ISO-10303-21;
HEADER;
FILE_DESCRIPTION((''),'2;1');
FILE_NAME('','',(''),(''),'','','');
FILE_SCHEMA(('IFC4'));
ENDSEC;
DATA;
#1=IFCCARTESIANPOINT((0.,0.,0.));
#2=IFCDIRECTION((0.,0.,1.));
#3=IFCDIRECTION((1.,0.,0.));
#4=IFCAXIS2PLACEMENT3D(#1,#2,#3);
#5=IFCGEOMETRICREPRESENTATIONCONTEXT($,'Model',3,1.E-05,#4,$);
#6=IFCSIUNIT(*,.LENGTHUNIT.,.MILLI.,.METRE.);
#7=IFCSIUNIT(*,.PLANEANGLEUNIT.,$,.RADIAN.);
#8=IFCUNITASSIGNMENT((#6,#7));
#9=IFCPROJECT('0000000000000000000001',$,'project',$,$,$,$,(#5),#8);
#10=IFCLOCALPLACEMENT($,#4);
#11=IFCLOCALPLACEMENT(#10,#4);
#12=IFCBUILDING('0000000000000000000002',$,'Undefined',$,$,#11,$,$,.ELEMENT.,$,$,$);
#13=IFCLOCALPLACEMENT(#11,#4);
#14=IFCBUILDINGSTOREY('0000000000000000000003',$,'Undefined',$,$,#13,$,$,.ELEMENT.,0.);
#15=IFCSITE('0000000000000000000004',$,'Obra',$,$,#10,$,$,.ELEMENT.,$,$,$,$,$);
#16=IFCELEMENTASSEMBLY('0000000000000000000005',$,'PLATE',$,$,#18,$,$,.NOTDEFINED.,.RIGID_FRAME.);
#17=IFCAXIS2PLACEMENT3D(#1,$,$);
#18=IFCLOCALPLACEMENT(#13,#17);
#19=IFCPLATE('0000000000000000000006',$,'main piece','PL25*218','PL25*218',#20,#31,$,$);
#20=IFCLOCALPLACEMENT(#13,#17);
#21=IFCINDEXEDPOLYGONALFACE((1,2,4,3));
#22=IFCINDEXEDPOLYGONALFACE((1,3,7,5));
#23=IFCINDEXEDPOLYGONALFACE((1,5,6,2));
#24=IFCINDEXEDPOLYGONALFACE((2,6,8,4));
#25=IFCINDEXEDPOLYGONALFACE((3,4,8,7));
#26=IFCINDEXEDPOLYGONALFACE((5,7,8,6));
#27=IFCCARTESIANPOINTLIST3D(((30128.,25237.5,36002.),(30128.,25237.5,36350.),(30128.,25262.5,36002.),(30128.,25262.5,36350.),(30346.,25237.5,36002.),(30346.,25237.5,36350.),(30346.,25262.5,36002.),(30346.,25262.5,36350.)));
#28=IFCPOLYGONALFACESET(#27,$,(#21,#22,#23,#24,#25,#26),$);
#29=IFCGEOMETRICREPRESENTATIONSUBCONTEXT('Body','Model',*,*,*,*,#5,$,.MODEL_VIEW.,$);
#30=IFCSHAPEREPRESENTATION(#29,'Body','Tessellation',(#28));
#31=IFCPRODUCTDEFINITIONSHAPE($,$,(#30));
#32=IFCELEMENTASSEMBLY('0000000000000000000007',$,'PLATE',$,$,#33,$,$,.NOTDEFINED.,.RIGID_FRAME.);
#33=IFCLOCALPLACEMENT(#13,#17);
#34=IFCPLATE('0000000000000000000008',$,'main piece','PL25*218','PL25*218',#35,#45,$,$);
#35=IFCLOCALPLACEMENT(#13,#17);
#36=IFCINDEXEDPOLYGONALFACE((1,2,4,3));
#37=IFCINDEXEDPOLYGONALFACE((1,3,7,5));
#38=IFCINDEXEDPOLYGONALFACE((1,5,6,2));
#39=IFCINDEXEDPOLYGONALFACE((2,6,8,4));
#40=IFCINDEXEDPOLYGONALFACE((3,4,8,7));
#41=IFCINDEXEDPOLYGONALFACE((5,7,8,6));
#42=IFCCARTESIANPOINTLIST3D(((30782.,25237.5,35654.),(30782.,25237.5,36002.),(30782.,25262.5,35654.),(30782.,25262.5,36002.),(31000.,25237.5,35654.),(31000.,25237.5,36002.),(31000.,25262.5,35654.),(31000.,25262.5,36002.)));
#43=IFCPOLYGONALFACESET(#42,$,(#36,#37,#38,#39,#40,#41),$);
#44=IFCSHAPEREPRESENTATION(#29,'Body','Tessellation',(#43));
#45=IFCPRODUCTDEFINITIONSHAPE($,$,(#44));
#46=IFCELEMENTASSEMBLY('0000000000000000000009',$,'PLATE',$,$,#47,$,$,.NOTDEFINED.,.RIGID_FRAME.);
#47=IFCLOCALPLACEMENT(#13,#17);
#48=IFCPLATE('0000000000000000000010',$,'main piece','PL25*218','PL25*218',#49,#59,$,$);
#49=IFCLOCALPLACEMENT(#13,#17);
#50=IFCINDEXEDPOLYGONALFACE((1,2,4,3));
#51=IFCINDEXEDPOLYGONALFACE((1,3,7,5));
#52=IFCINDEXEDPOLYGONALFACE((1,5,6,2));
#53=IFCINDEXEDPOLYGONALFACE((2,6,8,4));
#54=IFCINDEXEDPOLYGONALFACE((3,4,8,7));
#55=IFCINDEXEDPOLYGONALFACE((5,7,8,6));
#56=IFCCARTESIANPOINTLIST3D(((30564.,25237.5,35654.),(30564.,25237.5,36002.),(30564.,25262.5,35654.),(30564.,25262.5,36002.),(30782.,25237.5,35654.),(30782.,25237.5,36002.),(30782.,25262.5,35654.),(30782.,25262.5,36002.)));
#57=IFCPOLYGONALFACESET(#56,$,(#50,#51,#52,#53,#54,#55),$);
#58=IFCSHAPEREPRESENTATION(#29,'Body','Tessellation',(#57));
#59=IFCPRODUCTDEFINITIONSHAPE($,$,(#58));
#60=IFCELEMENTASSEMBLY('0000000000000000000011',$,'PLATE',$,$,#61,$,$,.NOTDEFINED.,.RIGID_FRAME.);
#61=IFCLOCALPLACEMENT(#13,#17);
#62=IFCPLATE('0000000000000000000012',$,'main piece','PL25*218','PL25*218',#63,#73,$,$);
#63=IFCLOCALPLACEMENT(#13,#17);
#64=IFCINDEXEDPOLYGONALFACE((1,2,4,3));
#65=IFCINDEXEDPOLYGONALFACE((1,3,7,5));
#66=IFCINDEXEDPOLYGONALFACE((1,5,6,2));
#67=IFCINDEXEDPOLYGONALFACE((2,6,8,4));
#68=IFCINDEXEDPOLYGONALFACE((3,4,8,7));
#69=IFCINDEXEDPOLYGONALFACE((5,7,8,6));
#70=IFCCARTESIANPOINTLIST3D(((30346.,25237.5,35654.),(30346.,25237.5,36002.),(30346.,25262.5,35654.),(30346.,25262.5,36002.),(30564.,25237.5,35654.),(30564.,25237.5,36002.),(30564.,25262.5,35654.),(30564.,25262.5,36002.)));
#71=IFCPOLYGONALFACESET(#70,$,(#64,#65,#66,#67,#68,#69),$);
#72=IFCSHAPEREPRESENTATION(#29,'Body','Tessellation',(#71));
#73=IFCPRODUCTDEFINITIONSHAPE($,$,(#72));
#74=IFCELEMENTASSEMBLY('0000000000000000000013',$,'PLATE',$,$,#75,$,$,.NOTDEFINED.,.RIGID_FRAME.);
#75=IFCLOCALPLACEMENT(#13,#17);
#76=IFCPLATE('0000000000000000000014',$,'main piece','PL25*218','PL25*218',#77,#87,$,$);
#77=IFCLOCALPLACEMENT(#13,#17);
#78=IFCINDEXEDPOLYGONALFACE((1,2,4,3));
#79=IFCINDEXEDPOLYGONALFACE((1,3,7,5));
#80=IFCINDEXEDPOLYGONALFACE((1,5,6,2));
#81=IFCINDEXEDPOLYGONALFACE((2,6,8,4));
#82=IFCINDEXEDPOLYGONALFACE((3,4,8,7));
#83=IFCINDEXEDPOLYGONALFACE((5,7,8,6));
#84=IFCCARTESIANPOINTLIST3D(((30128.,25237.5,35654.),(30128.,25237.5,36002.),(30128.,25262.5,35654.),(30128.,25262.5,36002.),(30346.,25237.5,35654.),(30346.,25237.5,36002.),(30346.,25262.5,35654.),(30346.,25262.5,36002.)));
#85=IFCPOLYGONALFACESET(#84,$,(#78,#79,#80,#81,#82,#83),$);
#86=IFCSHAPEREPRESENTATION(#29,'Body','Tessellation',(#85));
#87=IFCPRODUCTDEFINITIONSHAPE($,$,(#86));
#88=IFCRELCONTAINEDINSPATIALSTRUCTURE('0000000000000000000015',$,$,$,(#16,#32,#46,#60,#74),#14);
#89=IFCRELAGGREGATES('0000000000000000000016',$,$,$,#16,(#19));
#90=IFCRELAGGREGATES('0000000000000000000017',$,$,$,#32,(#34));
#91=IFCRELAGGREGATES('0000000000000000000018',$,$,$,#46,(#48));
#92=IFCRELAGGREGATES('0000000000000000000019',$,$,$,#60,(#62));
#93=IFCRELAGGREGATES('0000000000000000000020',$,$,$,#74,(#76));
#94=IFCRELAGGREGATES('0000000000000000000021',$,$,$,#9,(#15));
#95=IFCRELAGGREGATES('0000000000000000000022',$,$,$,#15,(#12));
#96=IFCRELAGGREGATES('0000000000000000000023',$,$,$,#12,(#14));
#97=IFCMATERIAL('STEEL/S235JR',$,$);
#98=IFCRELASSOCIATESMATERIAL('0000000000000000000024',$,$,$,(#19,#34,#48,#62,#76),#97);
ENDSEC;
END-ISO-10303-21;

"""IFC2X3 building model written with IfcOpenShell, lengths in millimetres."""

from ifc_helpers import new_model, si_unit, frame, origin_with_axes, place, context, subcontext, project, spatial, polyline, outline, extrude, material, element, aggregate, save


model = new_model("IFC2X3")

# Units and contexts
model_context = context("Model", 3, precision=1e-05, world=origin_with_axes())
body_context = subcontext(model_context, "Body", "Model", "MODEL_VIEW")
ifc_project = project(units=[si_unit("LENGTHUNIT", "METRE", prefix="MILLI"), si_unit("PLANEANGLEUNIT", "RADIAN")], contexts=[model_context])

# Site, building, storey
site_placement = place(None, origin_with_axes())
site = spatial("IfcSite", under=ifc_project, at=site_placement, Name="Obra", CompositionType="ELEMENT")
building_placement = place(site_placement, origin_with_axes())
building = spatial("IfcBuilding", under=site, at=building_placement, Name="Undefined", CompositionType="ELEMENT")
storey_placement = place(building_placement, origin_with_axes())
storey = spatial("IfcBuildingStorey", under=building, at=storey_placement, Name="Undefined", CompositionType="ELEMENT", Elevation=0.0)

# Shared definitions
ifc_material_1 = material(Name="STEEL/S235JR")

# Element assemblies, plates
assembly_1_placement = place(storey_placement, origin_with_axes())
assembly_1 = element("IfcElementAssembly", 1, at=assembly_1_placement, inside=storey, Name="PLATE", AssemblyPlace="NOTDEFINED", PredefinedType="RIGID_FRAME")
plate_1_placement = place(assembly_1_placement, frame((30128.0, 25250.0, 36002.0), z_axis=(0.0, -1.0, 0.0), x_axis=(1.0, 0.0, 0.0)))
plate_1 = element("IfcPlate", 2, at=plate_1_placement, material=ifc_material_1, Name="main piece", Description="PL25*218", ObjectType="PL25*218", context=body_context, shape_type="SweptSolid", body=[
    extrude(outline(polyline([(0.0, 0.0), (218.0, 0.0), (218.0, 348.0), (0.0, 348.0), (0.0, 0.0)])), frame((0.0, 0.0, -12.5), z_axis=(0.0, 0.0, 1.0), x_axis=(1.0, 0.0, 0.0)), (0.0, 0.0, 1.0), 25.0),
])
aggregate(assembly_1, [plate_1])
assembly_2_placement = place(storey_placement, origin_with_axes())
assembly_2 = element("IfcElementAssembly", 3, at=assembly_2_placement, inside=storey, Name="PLATE", AssemblyPlace="NOTDEFINED", PredefinedType="RIGID_FRAME")
plate_2_placement = place(assembly_2_placement, frame((30782.0, 25250.0, 35654.0), z_axis=(0.0, -1.0, 0.0), x_axis=(1.0, 0.0, 0.0)))
plate_2 = element("IfcPlate", 4, at=plate_2_placement, material=ifc_material_1, Name="main piece", Description="PL25*218", ObjectType="PL25*218", context=body_context, shape_type="SweptSolid", body=[
    extrude(outline(polyline([(0.0, 0.0), (218.0, 0.0), (218.0, 348.0), (0.0, 348.0), (0.0, 0.0)])), frame((0.0, 0.0, -12.5), z_axis=(0.0, 0.0, 1.0), x_axis=(1.0, 0.0, 0.0)), (0.0, 0.0, 1.0), 25.0),
])
aggregate(assembly_2, [plate_2])
assembly_3_placement = place(storey_placement, origin_with_axes())
assembly_3 = element("IfcElementAssembly", 5, at=assembly_3_placement, inside=storey, Name="PLATE", AssemblyPlace="NOTDEFINED", PredefinedType="RIGID_FRAME")
plate_3_placement = place(assembly_3_placement, frame((30564.0, 25250.0, 35654.0), z_axis=(0.0, -1.0, 0.0), x_axis=(1.0, 0.0, 0.0)))
plate_3 = element("IfcPlate", 6, at=plate_3_placement, material=ifc_material_1, Name="main piece", Description="PL25*218", ObjectType="PL25*218", context=body_context, shape_type="SweptSolid", body=[
    extrude(outline(polyline([(0.0, 0.0), (218.0, 0.0), (218.0, 348.0), (0.0, 348.0), (0.0, 0.0)])), frame((0.0, 0.0, -12.5), z_axis=(0.0, 0.0, 1.0), x_axis=(1.0, 0.0, 0.0)), (0.0, 0.0, 1.0), 25.0),
])
aggregate(assembly_3, [plate_3])
assembly_4_placement = place(storey_placement, origin_with_axes())
assembly_4 = element("IfcElementAssembly", 7, at=assembly_4_placement, inside=storey, Name="PLATE", AssemblyPlace="NOTDEFINED", PredefinedType="RIGID_FRAME")
plate_4_placement = place(assembly_4_placement, frame((30346.0, 25250.0, 35654.0), z_axis=(0.0, -1.0, 0.0), x_axis=(1.0, 0.0, 0.0)))
plate_4 = element("IfcPlate", 8, at=plate_4_placement, material=ifc_material_1, Name="main piece", Description="PL25*218", ObjectType="PL25*218", context=body_context, shape_type="SweptSolid", body=[
    extrude(outline(polyline([(0.0, 0.0), (218.0, 0.0), (218.0, 348.0), (0.0, 348.0), (0.0, 0.0)])), frame((0.0, 0.0, -12.5), z_axis=(0.0, 0.0, 1.0), x_axis=(1.0, 0.0, 0.0)), (0.0, 0.0, 1.0), 25.0),
])
aggregate(assembly_4, [plate_4])
assembly_5_placement = place(storey_placement, origin_with_axes())
assembly_5 = element("IfcElementAssembly", 9, at=assembly_5_placement, inside=storey, Name="PLATE", AssemblyPlace="NOTDEFINED", PredefinedType="RIGID_FRAME")
plate_5_placement = place(assembly_5_placement, frame((30128.0, 25250.0, 35654.0), z_axis=(0.0, -1.0, 0.0), x_axis=(1.0, 0.0, 0.0)))
plate_5 = element("IfcPlate", 10, at=plate_5_placement, material=ifc_material_1, Name="main piece", Description="PL25*218", ObjectType="PL25*218", context=body_context, shape_type="SweptSolid", body=[
    extrude(outline(polyline([(0.0, 0.0), (218.0, 0.0), (218.0, 348.0), (0.0, 348.0), (0.0, 0.0)])), frame((0.0, 0.0, -12.5), z_axis=(0.0, 0.0, 1.0), x_axis=(1.0, 0.0, 0.0)), (0.0, 0.0, 1.0), 25.0),
])
aggregate(assembly_5, [plate_5])

save(model, "model.ifc")
